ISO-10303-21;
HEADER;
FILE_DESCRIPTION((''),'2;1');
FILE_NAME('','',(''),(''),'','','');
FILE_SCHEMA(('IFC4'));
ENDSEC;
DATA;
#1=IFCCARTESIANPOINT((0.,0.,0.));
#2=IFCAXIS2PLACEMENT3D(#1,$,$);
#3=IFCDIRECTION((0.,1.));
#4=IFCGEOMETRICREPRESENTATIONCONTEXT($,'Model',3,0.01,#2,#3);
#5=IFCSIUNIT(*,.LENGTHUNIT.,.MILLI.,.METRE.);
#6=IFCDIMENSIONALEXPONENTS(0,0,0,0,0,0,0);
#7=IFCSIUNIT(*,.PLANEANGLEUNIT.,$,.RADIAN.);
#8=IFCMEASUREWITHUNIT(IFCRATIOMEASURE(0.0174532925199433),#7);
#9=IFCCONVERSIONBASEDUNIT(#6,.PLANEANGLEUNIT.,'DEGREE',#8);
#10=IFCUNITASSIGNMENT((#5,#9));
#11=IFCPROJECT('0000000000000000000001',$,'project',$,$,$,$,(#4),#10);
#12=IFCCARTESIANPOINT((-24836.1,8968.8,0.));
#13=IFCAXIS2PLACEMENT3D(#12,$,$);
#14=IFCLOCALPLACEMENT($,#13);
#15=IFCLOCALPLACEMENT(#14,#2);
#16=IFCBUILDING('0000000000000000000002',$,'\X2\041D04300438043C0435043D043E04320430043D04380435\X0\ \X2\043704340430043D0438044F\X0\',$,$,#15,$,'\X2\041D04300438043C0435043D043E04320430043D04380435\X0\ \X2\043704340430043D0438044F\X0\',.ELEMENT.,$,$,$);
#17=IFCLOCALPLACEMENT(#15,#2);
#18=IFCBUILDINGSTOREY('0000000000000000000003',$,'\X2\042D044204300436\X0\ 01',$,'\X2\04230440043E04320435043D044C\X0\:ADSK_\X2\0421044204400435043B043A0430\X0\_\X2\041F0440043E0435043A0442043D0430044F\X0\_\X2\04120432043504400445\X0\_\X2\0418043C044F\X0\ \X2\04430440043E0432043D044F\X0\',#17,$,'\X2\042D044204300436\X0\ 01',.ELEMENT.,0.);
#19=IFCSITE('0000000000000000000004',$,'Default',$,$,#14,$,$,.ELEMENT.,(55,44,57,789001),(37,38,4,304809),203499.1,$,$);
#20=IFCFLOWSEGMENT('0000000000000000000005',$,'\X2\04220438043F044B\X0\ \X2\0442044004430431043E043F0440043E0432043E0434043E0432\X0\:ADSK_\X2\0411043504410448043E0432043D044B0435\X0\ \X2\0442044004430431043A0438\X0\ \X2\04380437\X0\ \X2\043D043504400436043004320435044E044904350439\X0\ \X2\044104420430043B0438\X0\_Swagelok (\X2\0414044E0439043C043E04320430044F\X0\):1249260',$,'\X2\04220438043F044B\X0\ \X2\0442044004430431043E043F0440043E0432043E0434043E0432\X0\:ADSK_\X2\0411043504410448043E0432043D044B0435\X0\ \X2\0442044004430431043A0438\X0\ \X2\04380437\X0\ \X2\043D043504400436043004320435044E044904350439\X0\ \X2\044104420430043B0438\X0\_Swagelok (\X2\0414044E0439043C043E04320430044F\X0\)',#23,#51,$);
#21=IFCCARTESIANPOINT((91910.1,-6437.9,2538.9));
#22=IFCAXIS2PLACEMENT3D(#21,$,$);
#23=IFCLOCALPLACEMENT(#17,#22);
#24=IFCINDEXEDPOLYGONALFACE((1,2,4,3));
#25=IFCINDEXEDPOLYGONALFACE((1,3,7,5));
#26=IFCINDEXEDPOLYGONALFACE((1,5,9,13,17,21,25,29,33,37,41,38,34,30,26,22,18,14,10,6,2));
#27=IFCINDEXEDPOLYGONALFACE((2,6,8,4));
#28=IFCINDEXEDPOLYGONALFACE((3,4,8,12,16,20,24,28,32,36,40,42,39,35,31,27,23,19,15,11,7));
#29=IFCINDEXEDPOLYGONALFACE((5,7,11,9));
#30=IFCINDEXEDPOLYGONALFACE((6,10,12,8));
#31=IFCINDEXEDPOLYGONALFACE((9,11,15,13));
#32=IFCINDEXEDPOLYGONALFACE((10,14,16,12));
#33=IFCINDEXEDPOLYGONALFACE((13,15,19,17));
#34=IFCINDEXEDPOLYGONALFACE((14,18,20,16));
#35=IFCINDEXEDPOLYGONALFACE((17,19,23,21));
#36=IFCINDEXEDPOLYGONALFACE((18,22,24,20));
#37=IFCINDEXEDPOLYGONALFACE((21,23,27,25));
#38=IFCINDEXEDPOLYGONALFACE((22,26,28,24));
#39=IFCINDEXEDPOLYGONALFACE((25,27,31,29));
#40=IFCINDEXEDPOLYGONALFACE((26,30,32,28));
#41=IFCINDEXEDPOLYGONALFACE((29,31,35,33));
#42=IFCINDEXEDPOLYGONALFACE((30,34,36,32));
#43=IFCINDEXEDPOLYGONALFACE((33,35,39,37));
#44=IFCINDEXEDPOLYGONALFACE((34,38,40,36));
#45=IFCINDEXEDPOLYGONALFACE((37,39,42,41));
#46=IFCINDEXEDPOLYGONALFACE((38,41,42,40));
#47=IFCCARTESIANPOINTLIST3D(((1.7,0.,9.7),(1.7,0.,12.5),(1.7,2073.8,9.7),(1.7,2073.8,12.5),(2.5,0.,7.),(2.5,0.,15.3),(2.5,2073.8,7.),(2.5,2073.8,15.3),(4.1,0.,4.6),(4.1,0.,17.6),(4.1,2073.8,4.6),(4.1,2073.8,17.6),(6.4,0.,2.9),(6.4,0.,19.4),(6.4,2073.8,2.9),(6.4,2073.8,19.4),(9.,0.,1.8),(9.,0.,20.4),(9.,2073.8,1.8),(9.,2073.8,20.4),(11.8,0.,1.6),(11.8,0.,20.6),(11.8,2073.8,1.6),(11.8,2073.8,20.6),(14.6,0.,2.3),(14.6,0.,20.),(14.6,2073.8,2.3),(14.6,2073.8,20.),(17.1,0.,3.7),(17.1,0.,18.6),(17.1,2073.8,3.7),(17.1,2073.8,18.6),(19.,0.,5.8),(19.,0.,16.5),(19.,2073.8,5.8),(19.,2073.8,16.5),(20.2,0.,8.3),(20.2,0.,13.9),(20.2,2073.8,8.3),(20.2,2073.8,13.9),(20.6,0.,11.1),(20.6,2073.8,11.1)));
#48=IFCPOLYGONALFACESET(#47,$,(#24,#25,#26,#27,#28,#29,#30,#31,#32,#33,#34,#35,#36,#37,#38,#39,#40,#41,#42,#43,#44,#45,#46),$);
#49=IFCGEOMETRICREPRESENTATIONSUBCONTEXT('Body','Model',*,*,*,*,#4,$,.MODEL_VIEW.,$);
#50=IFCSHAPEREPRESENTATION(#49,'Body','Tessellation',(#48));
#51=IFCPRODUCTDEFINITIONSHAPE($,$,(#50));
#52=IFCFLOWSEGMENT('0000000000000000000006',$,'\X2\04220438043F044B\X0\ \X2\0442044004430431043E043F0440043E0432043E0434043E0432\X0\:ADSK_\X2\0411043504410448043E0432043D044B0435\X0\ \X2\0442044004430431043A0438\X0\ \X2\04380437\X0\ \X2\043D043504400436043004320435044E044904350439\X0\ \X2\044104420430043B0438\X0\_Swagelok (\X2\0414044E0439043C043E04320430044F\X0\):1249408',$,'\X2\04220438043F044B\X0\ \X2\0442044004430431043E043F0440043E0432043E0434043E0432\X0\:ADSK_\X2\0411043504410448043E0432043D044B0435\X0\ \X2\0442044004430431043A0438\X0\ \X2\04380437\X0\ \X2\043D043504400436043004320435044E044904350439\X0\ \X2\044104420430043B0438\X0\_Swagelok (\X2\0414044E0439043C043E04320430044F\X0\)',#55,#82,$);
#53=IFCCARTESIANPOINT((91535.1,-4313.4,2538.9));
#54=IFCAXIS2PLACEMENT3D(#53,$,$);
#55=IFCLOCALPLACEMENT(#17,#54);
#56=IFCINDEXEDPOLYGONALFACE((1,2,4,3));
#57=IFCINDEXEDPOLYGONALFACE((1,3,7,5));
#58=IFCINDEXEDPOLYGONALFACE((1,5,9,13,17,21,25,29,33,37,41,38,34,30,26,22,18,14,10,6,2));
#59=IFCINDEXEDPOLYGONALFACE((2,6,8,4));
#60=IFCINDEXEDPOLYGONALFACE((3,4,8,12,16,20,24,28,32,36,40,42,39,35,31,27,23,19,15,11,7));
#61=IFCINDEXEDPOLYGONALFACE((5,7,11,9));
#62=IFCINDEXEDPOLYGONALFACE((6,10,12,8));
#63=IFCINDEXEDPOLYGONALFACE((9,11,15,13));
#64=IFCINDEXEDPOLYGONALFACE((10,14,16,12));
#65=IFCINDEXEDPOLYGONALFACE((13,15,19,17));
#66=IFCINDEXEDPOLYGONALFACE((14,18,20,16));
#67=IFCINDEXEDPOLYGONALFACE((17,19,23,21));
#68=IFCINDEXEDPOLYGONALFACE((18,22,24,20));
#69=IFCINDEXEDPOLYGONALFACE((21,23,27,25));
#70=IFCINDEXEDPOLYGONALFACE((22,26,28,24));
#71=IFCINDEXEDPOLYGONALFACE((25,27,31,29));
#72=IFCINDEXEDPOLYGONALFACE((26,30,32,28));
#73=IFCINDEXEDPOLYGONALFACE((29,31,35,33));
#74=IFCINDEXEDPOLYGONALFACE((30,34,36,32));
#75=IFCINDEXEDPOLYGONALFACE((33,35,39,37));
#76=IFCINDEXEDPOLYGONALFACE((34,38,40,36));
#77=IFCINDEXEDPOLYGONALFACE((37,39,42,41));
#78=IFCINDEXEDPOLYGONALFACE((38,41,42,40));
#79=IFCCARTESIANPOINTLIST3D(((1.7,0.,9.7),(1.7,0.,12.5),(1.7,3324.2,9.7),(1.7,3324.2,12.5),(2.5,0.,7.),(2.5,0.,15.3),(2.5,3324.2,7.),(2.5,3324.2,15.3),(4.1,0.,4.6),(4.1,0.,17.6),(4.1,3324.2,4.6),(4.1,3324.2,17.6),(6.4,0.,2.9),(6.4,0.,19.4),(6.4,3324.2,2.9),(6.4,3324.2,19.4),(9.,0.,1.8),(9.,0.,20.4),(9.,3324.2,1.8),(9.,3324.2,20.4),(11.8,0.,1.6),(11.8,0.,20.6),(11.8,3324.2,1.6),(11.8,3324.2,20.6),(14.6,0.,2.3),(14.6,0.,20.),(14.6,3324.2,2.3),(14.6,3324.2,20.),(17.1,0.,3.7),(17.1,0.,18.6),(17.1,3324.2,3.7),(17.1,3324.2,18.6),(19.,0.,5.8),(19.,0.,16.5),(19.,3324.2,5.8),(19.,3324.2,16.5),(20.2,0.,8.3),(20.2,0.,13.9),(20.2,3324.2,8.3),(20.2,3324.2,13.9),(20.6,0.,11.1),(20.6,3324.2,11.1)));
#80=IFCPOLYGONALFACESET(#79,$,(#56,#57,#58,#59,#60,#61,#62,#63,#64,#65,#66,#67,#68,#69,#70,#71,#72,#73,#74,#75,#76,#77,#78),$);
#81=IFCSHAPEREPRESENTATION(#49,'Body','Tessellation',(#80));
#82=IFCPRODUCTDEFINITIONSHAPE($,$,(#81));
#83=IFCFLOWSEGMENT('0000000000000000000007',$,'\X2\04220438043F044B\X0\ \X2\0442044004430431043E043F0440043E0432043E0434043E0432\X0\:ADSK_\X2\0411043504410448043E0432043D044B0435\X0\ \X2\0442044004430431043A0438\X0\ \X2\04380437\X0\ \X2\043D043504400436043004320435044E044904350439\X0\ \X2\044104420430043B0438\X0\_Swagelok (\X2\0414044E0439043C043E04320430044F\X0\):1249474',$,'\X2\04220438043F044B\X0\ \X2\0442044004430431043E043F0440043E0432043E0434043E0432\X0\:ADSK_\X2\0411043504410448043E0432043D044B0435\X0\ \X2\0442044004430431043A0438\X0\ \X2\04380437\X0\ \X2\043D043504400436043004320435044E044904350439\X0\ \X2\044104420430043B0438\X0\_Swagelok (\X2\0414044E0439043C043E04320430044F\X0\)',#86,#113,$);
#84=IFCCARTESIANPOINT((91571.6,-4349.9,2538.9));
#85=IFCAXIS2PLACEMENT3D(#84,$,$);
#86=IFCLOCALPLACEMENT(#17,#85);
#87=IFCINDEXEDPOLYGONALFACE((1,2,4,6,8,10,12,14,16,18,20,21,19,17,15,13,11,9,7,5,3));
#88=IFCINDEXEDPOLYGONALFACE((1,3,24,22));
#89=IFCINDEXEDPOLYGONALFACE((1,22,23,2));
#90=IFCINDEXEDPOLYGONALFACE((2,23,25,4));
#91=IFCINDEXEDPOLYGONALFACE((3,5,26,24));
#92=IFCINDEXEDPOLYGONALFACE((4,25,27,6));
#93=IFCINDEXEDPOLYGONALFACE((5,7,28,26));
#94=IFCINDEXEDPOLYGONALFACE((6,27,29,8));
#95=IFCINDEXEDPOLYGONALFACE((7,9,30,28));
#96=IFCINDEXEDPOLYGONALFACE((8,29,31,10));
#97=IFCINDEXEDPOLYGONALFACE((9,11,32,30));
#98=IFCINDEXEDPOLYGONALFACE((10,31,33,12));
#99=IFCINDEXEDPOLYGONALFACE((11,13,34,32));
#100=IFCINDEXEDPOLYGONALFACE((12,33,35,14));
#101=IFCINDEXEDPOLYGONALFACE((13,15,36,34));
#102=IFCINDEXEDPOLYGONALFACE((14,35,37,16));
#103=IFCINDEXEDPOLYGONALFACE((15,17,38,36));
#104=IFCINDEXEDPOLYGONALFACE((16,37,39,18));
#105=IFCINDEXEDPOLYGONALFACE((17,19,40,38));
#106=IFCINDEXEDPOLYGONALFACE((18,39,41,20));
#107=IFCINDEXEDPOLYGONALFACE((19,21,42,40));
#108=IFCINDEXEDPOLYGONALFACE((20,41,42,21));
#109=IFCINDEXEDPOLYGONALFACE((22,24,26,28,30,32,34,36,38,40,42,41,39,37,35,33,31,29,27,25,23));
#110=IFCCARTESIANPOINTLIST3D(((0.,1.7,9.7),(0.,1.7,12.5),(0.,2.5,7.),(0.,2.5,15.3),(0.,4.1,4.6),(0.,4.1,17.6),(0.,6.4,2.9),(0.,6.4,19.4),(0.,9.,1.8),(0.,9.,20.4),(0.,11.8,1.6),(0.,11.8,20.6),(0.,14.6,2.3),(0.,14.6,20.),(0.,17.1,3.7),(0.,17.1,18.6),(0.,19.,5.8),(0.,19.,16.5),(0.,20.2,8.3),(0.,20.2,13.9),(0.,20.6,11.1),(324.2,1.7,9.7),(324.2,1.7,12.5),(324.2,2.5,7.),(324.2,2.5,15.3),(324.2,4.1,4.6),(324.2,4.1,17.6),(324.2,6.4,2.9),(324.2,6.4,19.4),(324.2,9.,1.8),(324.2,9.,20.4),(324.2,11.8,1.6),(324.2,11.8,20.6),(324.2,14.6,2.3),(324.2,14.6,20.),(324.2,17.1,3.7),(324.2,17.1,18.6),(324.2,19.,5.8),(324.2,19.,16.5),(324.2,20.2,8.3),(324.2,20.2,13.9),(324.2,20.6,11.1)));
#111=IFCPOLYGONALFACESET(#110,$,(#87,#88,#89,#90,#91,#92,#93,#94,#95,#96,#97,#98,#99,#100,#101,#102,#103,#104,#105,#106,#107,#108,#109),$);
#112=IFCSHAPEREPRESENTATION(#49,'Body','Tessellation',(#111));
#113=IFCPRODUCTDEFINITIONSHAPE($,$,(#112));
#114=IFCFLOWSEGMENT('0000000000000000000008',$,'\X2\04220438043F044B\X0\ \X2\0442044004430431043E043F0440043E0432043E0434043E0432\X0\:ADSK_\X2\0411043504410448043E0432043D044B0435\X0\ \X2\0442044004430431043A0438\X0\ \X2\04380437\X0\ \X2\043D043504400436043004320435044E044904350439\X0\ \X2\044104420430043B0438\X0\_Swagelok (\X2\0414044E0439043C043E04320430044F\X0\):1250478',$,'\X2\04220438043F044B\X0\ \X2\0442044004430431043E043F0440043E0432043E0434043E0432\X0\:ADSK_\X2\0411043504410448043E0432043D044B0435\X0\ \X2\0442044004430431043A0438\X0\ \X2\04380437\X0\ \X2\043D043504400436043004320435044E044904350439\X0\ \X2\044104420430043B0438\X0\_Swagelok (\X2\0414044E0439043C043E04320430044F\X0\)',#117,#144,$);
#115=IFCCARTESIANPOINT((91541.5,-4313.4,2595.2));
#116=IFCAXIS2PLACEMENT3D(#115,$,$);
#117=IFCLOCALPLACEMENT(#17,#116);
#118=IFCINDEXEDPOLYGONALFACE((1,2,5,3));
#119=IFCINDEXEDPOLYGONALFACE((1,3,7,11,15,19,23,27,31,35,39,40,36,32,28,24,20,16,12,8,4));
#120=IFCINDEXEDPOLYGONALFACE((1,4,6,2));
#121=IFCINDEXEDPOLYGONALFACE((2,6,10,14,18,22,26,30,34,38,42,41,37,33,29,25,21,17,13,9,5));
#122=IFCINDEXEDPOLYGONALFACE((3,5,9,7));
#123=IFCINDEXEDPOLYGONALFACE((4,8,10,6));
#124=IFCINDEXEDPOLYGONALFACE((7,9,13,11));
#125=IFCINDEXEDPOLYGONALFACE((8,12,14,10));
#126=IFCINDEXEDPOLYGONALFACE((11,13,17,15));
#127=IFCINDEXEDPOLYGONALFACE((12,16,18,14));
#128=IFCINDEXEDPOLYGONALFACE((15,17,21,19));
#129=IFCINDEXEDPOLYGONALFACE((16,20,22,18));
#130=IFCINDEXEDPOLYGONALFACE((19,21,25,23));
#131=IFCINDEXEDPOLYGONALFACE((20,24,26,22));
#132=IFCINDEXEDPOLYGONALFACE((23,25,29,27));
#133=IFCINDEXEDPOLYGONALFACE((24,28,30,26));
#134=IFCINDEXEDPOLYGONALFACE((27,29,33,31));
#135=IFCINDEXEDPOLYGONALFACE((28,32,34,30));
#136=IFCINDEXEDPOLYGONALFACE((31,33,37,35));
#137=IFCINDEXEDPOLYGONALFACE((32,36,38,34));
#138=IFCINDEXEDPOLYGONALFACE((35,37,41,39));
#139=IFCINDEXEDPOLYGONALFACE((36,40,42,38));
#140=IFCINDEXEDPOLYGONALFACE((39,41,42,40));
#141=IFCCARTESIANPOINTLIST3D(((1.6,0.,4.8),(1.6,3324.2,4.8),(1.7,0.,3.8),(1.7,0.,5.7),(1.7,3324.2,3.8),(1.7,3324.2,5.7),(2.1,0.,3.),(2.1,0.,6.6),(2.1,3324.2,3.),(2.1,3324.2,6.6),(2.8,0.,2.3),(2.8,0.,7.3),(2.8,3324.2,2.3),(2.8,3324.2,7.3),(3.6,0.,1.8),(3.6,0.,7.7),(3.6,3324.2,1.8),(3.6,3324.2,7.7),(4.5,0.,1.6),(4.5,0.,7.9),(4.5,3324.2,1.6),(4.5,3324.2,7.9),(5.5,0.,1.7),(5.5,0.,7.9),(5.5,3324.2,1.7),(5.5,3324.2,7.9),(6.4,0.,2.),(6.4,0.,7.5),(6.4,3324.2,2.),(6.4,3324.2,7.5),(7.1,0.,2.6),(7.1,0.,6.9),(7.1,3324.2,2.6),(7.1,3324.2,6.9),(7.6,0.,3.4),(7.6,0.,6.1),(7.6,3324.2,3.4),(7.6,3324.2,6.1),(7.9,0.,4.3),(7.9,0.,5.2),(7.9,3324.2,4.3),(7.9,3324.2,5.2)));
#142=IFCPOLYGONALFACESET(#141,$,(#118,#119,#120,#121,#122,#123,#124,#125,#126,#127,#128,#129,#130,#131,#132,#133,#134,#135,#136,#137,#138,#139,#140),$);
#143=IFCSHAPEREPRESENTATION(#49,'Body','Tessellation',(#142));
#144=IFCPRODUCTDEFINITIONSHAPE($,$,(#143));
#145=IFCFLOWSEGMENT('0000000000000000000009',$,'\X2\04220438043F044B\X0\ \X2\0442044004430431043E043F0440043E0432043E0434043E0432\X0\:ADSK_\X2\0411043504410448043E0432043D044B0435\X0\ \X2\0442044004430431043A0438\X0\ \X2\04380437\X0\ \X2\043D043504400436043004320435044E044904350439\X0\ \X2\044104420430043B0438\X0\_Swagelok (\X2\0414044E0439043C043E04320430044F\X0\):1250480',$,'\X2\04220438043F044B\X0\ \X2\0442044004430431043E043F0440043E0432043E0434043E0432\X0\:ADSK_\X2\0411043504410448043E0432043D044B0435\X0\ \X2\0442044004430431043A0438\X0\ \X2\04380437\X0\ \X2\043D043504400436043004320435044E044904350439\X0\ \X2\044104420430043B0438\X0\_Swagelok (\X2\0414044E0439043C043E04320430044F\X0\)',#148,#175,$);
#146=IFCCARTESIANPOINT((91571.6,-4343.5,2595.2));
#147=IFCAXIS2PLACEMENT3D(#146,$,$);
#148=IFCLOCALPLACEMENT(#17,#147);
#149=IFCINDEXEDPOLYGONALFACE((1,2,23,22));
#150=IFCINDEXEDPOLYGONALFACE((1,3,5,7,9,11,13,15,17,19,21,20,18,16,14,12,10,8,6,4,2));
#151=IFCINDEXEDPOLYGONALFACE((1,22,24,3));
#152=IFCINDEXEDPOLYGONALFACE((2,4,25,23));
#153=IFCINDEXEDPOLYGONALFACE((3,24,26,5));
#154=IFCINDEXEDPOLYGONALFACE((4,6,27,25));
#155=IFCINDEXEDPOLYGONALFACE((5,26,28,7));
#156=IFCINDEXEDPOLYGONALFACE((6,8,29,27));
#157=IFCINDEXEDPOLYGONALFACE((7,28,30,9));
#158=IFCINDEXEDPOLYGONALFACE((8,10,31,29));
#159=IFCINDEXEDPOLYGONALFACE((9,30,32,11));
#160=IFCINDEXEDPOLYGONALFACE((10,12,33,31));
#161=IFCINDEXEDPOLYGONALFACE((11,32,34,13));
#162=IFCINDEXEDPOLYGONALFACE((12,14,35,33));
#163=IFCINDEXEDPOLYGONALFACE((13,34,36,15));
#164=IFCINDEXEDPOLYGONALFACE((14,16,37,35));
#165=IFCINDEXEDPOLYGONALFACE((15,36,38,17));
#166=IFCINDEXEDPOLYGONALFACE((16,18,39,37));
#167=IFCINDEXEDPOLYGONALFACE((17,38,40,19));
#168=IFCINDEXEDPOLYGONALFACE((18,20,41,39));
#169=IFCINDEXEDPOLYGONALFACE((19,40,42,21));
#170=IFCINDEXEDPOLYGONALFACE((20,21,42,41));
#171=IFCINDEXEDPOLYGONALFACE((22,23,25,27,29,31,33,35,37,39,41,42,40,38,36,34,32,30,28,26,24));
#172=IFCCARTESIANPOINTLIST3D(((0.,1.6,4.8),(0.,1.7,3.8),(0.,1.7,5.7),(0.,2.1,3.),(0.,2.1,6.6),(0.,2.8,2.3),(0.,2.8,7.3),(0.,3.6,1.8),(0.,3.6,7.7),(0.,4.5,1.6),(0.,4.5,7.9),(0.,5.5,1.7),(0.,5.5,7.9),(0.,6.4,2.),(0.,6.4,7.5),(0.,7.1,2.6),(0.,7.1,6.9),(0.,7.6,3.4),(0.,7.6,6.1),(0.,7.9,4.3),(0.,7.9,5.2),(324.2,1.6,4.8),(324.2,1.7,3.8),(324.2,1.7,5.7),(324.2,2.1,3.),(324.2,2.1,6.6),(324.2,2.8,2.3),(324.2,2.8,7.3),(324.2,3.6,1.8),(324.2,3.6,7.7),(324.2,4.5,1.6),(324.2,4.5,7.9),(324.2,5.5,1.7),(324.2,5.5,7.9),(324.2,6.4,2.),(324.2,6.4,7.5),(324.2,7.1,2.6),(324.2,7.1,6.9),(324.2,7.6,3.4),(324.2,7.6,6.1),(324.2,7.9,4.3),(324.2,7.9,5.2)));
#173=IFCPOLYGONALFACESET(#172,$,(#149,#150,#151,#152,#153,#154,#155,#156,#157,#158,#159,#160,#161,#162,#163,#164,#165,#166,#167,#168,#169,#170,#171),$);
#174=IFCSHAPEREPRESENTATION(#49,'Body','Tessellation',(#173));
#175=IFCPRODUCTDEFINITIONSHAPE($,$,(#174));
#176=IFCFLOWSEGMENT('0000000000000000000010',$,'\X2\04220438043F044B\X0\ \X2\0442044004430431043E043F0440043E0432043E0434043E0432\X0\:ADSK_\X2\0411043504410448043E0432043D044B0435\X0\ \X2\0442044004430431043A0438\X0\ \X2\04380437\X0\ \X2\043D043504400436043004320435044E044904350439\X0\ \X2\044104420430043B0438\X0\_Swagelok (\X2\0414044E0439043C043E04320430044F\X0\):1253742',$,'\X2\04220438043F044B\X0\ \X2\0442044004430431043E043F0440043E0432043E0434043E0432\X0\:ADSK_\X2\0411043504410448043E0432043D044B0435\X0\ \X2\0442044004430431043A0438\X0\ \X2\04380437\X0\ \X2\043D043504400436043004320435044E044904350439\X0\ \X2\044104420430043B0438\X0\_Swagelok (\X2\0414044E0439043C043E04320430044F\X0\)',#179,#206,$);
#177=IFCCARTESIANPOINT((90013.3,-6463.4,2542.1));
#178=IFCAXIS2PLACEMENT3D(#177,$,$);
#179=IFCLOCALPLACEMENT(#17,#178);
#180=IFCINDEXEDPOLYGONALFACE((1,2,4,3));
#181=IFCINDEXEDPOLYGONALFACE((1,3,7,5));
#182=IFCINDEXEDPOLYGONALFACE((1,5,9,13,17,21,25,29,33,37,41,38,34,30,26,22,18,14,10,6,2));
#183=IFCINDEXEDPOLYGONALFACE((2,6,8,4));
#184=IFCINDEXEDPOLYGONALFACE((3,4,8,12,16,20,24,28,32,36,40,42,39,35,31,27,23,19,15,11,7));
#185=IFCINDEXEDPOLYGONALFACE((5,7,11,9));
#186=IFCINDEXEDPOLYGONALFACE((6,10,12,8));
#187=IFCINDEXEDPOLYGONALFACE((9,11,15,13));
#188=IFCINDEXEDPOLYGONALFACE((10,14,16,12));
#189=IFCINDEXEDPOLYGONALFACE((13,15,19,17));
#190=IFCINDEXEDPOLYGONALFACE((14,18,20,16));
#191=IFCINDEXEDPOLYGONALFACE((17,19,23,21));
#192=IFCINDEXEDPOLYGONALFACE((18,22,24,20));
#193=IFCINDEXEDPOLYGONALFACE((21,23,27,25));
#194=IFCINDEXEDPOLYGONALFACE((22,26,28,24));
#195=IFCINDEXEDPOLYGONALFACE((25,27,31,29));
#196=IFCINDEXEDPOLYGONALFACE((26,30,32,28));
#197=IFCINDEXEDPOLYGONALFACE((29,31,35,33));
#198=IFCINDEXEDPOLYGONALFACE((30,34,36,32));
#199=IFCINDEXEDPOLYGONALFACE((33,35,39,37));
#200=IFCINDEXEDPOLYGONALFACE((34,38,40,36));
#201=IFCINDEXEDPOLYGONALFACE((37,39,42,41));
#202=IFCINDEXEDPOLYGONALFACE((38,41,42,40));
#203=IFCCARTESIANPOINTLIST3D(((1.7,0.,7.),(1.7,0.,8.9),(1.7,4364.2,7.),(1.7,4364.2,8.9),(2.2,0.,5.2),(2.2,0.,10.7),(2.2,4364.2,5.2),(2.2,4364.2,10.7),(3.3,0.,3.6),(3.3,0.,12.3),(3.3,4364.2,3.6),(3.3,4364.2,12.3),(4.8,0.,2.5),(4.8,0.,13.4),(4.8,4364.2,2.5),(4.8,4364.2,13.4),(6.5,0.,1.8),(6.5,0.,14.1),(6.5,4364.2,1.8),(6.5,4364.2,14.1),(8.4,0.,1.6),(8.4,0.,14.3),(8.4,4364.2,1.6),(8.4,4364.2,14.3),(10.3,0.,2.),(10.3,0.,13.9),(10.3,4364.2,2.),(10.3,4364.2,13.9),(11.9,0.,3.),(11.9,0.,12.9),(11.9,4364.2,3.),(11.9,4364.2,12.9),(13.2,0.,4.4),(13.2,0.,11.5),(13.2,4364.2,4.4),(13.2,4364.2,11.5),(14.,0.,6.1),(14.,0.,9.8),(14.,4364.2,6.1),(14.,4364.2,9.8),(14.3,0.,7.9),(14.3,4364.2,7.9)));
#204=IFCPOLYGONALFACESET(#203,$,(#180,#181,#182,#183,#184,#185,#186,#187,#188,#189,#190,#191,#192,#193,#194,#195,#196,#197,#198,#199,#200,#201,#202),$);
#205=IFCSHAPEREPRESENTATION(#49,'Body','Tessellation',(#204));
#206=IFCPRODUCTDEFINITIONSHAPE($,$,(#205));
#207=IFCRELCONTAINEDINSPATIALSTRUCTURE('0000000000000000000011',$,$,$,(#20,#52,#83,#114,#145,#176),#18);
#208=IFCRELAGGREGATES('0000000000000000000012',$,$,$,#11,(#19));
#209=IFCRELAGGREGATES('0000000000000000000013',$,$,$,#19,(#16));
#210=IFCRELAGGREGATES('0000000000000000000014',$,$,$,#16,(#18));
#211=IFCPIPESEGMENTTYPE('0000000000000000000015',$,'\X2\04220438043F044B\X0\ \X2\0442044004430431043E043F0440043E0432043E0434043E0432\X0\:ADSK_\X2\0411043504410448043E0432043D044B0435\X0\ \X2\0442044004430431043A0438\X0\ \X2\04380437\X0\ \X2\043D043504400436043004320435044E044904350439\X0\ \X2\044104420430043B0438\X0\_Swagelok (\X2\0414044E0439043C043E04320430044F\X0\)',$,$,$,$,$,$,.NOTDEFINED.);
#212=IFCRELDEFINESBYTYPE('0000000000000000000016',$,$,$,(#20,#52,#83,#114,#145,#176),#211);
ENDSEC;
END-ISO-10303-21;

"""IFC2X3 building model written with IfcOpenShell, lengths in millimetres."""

from ifc_helpers import new_model, entity, si_unit, converted_unit, direction, frame, origin, origin_2d_with_axis, place, context, subcontext, project, spatial, circle, extrude, type_object, element, save


model = new_model("IFC2X3")

# Units and contexts
model_context = context("Model", 3, precision=0.01, world=origin(), true_north=direction((0.0, 1.0)))
body_context = subcontext(model_context, "Body", "Model", "MODEL_VIEW")
ifc_project = project(units=[si_unit("LENGTHUNIT", "METRE", prefix="MILLI"), converted_unit("PLANEANGLEUNIT", "DEGREE", entity("IfcRatioMeasure", 0.0174532925199433), si_unit("PLANEANGLEUNIT", "RADIAN"), dimensions=[0, 0, 0, 0, 0, 0, 0])], contexts=[model_context])

# Site, building, storey
site_placement = place(None, frame((-24836.1, 8968.8, 0.0)))
site = spatial("IfcSite", under=ifc_project, at=site_placement, Name="Default", CompositionType="ELEMENT", RefLatitude=(55, 44, 57, 789001), RefLongitude=(37, 38, 4, 304809), RefElevation=203499.1)
building_placement = place(site_placement, origin())
building = spatial("IfcBuilding", under=site, at=building_placement, Name="Наименование здания", LongName="Наименование здания", CompositionType="ELEMENT")
storey_placement = place(building_placement, origin())
storey = spatial("IfcBuildingStorey", under=building, at=storey_placement, Name="Этаж 01", ObjectType="Уровень:ADSK_Стрелка_Проектная_Вверх_Имя уровня", LongName="Этаж 01", CompositionType="ELEMENT", Elevation=0.0)

# Flow segments
pipe_segment_type_1 = type_object("IfcPipeSegmentType", Name="Типы трубопроводов:ADSK_Бесшовные трубки из нержавеющей стали_Swagelok (Дюймовая)", PredefinedType="NOTDEFINED")
flow_segment_1_placement = place(storey_placement, frame((91910.1, -6437.9, 2538.9)))
element("IfcFlowSegment", 1, at=flow_segment_1_placement, inside=storey, type_object=pipe_segment_type_1, Name="Типы трубопроводов:ADSK_Бесшовные трубки из нержавеющей стали_Swagelok (Дюймовая):1249260", ObjectType="Типы трубопроводов:ADSK_Бесшовные трубки из нержавеющей стали_Swagelok (Дюймовая)", context=body_context, shape_type="SweptSolid", body=[
    extrude(circle(Radius=9.5, at=origin_2d_with_axis()), frame((11.1, 0.0, 11.1), z_axis=(0.0, 1.0, 0.0), x_axis=(1.0, 0.0, 0.0)), (0.0, 0.0, 1.0), 2073.8),
])
flow_segment_2_placement = place(storey_placement, frame((91535.1, -4313.4, 2538.9)))
element("IfcFlowSegment", 2, at=flow_segment_2_placement, inside=storey, type_object=pipe_segment_type_1, Name="Типы трубопроводов:ADSK_Бесшовные трубки из нержавеющей стали_Swagelok (Дюймовая):1249408", ObjectType="Типы трубопроводов:ADSK_Бесшовные трубки из нержавеющей стали_Swagelok (Дюймовая)", context=body_context, shape_type="SweptSolid", body=[
    extrude(circle(Radius=9.5, at=origin_2d_with_axis()), frame((11.1, 0.0, 11.1), z_axis=(0.0, 1.0, 0.0), x_axis=(1.0, 0.0, 0.0)), (0.0, 0.0, 1.0), 3324.2),
])
flow_segment_3_placement = place(storey_placement, frame((91571.6, -4349.9, 2538.9)))
element("IfcFlowSegment", 3, at=flow_segment_3_placement, inside=storey, type_object=pipe_segment_type_1, Name="Типы трубопроводов:ADSK_Бесшовные трубки из нержавеющей стали_Swagelok (Дюймовая):1249474", ObjectType="Типы трубопроводов:ADSK_Бесшовные трубки из нержавеющей стали_Swagelok (Дюймовая)", context=body_context, shape_type="SweptSolid", body=[
    extrude(circle(Radius=9.5, at=origin_2d_with_axis()), frame((0.0, 11.1, 11.1), z_axis=(1.0, 0.0, 0.0), x_axis=(0.0, 1.0, 0.0)), (0.0, 0.0, 1.0), 324.2),
])
flow_segment_4_placement = place(storey_placement, frame((91541.5, -4313.4, 2595.2)))
element("IfcFlowSegment", 4, at=flow_segment_4_placement, inside=storey, type_object=pipe_segment_type_1, Name="Типы трубопроводов:ADSK_Бесшовные трубки из нержавеющей стали_Swagelok (Дюймовая):1250478", ObjectType="Типы трубопроводов:ADSK_Бесшовные трубки из нержавеющей стали_Swagelok (Дюймовая)", context=body_context, shape_type="SweptSolid", body=[
    extrude(circle(Radius=3.2, at=origin_2d_with_axis()), frame((4.8, 0.0, 4.8), z_axis=(0.0, 1.0, 0.0), x_axis=(-1.0, 0.0, 0.0)), (0.0, 0.0, 1.0), 3324.2),
])
flow_segment_5_placement = place(storey_placement, frame((91571.6, -4343.5, 2595.2)))
element("IfcFlowSegment", 5, at=flow_segment_5_placement, inside=storey, type_object=pipe_segment_type_1, Name="Типы трубопроводов:ADSK_Бесшовные трубки из нержавеющей стали_Swagelok (Дюймовая):1250480", ObjectType="Типы трубопроводов:ADSK_Бесшовные трубки из нержавеющей стали_Swagelok (Дюймовая)", context=body_context, shape_type="SweptSolid", body=[
    extrude(circle(Radius=3.2, at=origin_2d_with_axis()), frame((0.0, 4.8, 4.8), z_axis=(1.0, 0.0, 0.0), x_axis=(0.0, -1.0, 0.0)), (0.0, 0.0, 1.0), 324.2),
])
flow_segment_6_placement = place(storey_placement, frame((90013.3, -6463.4, 2542.1)))
element("IfcFlowSegment", 6, at=flow_segment_6_placement, inside=storey, type_object=pipe_segment_type_1, Name="Типы трубопроводов:ADSK_Бесшовные трубки из нержавеющей стали_Swagelok (Дюймовая):1253742", ObjectType="Типы трубопроводов:ADSK_Бесшовные трубки из нержавеющей стали_Swagelok (Дюймовая)", context=body_context, shape_type="SweptSolid", body=[
    extrude(circle(Radius=6.3, at=origin_2d_with_axis()), frame((8.0, 0.0, 8.0), z_axis=(0.0, 1.0, 0.0), x_axis=(1.0, 0.0, 0.0)), (0.0, 0.0, 1.0), 4364.2),
])

save(model, "model.ifc")
